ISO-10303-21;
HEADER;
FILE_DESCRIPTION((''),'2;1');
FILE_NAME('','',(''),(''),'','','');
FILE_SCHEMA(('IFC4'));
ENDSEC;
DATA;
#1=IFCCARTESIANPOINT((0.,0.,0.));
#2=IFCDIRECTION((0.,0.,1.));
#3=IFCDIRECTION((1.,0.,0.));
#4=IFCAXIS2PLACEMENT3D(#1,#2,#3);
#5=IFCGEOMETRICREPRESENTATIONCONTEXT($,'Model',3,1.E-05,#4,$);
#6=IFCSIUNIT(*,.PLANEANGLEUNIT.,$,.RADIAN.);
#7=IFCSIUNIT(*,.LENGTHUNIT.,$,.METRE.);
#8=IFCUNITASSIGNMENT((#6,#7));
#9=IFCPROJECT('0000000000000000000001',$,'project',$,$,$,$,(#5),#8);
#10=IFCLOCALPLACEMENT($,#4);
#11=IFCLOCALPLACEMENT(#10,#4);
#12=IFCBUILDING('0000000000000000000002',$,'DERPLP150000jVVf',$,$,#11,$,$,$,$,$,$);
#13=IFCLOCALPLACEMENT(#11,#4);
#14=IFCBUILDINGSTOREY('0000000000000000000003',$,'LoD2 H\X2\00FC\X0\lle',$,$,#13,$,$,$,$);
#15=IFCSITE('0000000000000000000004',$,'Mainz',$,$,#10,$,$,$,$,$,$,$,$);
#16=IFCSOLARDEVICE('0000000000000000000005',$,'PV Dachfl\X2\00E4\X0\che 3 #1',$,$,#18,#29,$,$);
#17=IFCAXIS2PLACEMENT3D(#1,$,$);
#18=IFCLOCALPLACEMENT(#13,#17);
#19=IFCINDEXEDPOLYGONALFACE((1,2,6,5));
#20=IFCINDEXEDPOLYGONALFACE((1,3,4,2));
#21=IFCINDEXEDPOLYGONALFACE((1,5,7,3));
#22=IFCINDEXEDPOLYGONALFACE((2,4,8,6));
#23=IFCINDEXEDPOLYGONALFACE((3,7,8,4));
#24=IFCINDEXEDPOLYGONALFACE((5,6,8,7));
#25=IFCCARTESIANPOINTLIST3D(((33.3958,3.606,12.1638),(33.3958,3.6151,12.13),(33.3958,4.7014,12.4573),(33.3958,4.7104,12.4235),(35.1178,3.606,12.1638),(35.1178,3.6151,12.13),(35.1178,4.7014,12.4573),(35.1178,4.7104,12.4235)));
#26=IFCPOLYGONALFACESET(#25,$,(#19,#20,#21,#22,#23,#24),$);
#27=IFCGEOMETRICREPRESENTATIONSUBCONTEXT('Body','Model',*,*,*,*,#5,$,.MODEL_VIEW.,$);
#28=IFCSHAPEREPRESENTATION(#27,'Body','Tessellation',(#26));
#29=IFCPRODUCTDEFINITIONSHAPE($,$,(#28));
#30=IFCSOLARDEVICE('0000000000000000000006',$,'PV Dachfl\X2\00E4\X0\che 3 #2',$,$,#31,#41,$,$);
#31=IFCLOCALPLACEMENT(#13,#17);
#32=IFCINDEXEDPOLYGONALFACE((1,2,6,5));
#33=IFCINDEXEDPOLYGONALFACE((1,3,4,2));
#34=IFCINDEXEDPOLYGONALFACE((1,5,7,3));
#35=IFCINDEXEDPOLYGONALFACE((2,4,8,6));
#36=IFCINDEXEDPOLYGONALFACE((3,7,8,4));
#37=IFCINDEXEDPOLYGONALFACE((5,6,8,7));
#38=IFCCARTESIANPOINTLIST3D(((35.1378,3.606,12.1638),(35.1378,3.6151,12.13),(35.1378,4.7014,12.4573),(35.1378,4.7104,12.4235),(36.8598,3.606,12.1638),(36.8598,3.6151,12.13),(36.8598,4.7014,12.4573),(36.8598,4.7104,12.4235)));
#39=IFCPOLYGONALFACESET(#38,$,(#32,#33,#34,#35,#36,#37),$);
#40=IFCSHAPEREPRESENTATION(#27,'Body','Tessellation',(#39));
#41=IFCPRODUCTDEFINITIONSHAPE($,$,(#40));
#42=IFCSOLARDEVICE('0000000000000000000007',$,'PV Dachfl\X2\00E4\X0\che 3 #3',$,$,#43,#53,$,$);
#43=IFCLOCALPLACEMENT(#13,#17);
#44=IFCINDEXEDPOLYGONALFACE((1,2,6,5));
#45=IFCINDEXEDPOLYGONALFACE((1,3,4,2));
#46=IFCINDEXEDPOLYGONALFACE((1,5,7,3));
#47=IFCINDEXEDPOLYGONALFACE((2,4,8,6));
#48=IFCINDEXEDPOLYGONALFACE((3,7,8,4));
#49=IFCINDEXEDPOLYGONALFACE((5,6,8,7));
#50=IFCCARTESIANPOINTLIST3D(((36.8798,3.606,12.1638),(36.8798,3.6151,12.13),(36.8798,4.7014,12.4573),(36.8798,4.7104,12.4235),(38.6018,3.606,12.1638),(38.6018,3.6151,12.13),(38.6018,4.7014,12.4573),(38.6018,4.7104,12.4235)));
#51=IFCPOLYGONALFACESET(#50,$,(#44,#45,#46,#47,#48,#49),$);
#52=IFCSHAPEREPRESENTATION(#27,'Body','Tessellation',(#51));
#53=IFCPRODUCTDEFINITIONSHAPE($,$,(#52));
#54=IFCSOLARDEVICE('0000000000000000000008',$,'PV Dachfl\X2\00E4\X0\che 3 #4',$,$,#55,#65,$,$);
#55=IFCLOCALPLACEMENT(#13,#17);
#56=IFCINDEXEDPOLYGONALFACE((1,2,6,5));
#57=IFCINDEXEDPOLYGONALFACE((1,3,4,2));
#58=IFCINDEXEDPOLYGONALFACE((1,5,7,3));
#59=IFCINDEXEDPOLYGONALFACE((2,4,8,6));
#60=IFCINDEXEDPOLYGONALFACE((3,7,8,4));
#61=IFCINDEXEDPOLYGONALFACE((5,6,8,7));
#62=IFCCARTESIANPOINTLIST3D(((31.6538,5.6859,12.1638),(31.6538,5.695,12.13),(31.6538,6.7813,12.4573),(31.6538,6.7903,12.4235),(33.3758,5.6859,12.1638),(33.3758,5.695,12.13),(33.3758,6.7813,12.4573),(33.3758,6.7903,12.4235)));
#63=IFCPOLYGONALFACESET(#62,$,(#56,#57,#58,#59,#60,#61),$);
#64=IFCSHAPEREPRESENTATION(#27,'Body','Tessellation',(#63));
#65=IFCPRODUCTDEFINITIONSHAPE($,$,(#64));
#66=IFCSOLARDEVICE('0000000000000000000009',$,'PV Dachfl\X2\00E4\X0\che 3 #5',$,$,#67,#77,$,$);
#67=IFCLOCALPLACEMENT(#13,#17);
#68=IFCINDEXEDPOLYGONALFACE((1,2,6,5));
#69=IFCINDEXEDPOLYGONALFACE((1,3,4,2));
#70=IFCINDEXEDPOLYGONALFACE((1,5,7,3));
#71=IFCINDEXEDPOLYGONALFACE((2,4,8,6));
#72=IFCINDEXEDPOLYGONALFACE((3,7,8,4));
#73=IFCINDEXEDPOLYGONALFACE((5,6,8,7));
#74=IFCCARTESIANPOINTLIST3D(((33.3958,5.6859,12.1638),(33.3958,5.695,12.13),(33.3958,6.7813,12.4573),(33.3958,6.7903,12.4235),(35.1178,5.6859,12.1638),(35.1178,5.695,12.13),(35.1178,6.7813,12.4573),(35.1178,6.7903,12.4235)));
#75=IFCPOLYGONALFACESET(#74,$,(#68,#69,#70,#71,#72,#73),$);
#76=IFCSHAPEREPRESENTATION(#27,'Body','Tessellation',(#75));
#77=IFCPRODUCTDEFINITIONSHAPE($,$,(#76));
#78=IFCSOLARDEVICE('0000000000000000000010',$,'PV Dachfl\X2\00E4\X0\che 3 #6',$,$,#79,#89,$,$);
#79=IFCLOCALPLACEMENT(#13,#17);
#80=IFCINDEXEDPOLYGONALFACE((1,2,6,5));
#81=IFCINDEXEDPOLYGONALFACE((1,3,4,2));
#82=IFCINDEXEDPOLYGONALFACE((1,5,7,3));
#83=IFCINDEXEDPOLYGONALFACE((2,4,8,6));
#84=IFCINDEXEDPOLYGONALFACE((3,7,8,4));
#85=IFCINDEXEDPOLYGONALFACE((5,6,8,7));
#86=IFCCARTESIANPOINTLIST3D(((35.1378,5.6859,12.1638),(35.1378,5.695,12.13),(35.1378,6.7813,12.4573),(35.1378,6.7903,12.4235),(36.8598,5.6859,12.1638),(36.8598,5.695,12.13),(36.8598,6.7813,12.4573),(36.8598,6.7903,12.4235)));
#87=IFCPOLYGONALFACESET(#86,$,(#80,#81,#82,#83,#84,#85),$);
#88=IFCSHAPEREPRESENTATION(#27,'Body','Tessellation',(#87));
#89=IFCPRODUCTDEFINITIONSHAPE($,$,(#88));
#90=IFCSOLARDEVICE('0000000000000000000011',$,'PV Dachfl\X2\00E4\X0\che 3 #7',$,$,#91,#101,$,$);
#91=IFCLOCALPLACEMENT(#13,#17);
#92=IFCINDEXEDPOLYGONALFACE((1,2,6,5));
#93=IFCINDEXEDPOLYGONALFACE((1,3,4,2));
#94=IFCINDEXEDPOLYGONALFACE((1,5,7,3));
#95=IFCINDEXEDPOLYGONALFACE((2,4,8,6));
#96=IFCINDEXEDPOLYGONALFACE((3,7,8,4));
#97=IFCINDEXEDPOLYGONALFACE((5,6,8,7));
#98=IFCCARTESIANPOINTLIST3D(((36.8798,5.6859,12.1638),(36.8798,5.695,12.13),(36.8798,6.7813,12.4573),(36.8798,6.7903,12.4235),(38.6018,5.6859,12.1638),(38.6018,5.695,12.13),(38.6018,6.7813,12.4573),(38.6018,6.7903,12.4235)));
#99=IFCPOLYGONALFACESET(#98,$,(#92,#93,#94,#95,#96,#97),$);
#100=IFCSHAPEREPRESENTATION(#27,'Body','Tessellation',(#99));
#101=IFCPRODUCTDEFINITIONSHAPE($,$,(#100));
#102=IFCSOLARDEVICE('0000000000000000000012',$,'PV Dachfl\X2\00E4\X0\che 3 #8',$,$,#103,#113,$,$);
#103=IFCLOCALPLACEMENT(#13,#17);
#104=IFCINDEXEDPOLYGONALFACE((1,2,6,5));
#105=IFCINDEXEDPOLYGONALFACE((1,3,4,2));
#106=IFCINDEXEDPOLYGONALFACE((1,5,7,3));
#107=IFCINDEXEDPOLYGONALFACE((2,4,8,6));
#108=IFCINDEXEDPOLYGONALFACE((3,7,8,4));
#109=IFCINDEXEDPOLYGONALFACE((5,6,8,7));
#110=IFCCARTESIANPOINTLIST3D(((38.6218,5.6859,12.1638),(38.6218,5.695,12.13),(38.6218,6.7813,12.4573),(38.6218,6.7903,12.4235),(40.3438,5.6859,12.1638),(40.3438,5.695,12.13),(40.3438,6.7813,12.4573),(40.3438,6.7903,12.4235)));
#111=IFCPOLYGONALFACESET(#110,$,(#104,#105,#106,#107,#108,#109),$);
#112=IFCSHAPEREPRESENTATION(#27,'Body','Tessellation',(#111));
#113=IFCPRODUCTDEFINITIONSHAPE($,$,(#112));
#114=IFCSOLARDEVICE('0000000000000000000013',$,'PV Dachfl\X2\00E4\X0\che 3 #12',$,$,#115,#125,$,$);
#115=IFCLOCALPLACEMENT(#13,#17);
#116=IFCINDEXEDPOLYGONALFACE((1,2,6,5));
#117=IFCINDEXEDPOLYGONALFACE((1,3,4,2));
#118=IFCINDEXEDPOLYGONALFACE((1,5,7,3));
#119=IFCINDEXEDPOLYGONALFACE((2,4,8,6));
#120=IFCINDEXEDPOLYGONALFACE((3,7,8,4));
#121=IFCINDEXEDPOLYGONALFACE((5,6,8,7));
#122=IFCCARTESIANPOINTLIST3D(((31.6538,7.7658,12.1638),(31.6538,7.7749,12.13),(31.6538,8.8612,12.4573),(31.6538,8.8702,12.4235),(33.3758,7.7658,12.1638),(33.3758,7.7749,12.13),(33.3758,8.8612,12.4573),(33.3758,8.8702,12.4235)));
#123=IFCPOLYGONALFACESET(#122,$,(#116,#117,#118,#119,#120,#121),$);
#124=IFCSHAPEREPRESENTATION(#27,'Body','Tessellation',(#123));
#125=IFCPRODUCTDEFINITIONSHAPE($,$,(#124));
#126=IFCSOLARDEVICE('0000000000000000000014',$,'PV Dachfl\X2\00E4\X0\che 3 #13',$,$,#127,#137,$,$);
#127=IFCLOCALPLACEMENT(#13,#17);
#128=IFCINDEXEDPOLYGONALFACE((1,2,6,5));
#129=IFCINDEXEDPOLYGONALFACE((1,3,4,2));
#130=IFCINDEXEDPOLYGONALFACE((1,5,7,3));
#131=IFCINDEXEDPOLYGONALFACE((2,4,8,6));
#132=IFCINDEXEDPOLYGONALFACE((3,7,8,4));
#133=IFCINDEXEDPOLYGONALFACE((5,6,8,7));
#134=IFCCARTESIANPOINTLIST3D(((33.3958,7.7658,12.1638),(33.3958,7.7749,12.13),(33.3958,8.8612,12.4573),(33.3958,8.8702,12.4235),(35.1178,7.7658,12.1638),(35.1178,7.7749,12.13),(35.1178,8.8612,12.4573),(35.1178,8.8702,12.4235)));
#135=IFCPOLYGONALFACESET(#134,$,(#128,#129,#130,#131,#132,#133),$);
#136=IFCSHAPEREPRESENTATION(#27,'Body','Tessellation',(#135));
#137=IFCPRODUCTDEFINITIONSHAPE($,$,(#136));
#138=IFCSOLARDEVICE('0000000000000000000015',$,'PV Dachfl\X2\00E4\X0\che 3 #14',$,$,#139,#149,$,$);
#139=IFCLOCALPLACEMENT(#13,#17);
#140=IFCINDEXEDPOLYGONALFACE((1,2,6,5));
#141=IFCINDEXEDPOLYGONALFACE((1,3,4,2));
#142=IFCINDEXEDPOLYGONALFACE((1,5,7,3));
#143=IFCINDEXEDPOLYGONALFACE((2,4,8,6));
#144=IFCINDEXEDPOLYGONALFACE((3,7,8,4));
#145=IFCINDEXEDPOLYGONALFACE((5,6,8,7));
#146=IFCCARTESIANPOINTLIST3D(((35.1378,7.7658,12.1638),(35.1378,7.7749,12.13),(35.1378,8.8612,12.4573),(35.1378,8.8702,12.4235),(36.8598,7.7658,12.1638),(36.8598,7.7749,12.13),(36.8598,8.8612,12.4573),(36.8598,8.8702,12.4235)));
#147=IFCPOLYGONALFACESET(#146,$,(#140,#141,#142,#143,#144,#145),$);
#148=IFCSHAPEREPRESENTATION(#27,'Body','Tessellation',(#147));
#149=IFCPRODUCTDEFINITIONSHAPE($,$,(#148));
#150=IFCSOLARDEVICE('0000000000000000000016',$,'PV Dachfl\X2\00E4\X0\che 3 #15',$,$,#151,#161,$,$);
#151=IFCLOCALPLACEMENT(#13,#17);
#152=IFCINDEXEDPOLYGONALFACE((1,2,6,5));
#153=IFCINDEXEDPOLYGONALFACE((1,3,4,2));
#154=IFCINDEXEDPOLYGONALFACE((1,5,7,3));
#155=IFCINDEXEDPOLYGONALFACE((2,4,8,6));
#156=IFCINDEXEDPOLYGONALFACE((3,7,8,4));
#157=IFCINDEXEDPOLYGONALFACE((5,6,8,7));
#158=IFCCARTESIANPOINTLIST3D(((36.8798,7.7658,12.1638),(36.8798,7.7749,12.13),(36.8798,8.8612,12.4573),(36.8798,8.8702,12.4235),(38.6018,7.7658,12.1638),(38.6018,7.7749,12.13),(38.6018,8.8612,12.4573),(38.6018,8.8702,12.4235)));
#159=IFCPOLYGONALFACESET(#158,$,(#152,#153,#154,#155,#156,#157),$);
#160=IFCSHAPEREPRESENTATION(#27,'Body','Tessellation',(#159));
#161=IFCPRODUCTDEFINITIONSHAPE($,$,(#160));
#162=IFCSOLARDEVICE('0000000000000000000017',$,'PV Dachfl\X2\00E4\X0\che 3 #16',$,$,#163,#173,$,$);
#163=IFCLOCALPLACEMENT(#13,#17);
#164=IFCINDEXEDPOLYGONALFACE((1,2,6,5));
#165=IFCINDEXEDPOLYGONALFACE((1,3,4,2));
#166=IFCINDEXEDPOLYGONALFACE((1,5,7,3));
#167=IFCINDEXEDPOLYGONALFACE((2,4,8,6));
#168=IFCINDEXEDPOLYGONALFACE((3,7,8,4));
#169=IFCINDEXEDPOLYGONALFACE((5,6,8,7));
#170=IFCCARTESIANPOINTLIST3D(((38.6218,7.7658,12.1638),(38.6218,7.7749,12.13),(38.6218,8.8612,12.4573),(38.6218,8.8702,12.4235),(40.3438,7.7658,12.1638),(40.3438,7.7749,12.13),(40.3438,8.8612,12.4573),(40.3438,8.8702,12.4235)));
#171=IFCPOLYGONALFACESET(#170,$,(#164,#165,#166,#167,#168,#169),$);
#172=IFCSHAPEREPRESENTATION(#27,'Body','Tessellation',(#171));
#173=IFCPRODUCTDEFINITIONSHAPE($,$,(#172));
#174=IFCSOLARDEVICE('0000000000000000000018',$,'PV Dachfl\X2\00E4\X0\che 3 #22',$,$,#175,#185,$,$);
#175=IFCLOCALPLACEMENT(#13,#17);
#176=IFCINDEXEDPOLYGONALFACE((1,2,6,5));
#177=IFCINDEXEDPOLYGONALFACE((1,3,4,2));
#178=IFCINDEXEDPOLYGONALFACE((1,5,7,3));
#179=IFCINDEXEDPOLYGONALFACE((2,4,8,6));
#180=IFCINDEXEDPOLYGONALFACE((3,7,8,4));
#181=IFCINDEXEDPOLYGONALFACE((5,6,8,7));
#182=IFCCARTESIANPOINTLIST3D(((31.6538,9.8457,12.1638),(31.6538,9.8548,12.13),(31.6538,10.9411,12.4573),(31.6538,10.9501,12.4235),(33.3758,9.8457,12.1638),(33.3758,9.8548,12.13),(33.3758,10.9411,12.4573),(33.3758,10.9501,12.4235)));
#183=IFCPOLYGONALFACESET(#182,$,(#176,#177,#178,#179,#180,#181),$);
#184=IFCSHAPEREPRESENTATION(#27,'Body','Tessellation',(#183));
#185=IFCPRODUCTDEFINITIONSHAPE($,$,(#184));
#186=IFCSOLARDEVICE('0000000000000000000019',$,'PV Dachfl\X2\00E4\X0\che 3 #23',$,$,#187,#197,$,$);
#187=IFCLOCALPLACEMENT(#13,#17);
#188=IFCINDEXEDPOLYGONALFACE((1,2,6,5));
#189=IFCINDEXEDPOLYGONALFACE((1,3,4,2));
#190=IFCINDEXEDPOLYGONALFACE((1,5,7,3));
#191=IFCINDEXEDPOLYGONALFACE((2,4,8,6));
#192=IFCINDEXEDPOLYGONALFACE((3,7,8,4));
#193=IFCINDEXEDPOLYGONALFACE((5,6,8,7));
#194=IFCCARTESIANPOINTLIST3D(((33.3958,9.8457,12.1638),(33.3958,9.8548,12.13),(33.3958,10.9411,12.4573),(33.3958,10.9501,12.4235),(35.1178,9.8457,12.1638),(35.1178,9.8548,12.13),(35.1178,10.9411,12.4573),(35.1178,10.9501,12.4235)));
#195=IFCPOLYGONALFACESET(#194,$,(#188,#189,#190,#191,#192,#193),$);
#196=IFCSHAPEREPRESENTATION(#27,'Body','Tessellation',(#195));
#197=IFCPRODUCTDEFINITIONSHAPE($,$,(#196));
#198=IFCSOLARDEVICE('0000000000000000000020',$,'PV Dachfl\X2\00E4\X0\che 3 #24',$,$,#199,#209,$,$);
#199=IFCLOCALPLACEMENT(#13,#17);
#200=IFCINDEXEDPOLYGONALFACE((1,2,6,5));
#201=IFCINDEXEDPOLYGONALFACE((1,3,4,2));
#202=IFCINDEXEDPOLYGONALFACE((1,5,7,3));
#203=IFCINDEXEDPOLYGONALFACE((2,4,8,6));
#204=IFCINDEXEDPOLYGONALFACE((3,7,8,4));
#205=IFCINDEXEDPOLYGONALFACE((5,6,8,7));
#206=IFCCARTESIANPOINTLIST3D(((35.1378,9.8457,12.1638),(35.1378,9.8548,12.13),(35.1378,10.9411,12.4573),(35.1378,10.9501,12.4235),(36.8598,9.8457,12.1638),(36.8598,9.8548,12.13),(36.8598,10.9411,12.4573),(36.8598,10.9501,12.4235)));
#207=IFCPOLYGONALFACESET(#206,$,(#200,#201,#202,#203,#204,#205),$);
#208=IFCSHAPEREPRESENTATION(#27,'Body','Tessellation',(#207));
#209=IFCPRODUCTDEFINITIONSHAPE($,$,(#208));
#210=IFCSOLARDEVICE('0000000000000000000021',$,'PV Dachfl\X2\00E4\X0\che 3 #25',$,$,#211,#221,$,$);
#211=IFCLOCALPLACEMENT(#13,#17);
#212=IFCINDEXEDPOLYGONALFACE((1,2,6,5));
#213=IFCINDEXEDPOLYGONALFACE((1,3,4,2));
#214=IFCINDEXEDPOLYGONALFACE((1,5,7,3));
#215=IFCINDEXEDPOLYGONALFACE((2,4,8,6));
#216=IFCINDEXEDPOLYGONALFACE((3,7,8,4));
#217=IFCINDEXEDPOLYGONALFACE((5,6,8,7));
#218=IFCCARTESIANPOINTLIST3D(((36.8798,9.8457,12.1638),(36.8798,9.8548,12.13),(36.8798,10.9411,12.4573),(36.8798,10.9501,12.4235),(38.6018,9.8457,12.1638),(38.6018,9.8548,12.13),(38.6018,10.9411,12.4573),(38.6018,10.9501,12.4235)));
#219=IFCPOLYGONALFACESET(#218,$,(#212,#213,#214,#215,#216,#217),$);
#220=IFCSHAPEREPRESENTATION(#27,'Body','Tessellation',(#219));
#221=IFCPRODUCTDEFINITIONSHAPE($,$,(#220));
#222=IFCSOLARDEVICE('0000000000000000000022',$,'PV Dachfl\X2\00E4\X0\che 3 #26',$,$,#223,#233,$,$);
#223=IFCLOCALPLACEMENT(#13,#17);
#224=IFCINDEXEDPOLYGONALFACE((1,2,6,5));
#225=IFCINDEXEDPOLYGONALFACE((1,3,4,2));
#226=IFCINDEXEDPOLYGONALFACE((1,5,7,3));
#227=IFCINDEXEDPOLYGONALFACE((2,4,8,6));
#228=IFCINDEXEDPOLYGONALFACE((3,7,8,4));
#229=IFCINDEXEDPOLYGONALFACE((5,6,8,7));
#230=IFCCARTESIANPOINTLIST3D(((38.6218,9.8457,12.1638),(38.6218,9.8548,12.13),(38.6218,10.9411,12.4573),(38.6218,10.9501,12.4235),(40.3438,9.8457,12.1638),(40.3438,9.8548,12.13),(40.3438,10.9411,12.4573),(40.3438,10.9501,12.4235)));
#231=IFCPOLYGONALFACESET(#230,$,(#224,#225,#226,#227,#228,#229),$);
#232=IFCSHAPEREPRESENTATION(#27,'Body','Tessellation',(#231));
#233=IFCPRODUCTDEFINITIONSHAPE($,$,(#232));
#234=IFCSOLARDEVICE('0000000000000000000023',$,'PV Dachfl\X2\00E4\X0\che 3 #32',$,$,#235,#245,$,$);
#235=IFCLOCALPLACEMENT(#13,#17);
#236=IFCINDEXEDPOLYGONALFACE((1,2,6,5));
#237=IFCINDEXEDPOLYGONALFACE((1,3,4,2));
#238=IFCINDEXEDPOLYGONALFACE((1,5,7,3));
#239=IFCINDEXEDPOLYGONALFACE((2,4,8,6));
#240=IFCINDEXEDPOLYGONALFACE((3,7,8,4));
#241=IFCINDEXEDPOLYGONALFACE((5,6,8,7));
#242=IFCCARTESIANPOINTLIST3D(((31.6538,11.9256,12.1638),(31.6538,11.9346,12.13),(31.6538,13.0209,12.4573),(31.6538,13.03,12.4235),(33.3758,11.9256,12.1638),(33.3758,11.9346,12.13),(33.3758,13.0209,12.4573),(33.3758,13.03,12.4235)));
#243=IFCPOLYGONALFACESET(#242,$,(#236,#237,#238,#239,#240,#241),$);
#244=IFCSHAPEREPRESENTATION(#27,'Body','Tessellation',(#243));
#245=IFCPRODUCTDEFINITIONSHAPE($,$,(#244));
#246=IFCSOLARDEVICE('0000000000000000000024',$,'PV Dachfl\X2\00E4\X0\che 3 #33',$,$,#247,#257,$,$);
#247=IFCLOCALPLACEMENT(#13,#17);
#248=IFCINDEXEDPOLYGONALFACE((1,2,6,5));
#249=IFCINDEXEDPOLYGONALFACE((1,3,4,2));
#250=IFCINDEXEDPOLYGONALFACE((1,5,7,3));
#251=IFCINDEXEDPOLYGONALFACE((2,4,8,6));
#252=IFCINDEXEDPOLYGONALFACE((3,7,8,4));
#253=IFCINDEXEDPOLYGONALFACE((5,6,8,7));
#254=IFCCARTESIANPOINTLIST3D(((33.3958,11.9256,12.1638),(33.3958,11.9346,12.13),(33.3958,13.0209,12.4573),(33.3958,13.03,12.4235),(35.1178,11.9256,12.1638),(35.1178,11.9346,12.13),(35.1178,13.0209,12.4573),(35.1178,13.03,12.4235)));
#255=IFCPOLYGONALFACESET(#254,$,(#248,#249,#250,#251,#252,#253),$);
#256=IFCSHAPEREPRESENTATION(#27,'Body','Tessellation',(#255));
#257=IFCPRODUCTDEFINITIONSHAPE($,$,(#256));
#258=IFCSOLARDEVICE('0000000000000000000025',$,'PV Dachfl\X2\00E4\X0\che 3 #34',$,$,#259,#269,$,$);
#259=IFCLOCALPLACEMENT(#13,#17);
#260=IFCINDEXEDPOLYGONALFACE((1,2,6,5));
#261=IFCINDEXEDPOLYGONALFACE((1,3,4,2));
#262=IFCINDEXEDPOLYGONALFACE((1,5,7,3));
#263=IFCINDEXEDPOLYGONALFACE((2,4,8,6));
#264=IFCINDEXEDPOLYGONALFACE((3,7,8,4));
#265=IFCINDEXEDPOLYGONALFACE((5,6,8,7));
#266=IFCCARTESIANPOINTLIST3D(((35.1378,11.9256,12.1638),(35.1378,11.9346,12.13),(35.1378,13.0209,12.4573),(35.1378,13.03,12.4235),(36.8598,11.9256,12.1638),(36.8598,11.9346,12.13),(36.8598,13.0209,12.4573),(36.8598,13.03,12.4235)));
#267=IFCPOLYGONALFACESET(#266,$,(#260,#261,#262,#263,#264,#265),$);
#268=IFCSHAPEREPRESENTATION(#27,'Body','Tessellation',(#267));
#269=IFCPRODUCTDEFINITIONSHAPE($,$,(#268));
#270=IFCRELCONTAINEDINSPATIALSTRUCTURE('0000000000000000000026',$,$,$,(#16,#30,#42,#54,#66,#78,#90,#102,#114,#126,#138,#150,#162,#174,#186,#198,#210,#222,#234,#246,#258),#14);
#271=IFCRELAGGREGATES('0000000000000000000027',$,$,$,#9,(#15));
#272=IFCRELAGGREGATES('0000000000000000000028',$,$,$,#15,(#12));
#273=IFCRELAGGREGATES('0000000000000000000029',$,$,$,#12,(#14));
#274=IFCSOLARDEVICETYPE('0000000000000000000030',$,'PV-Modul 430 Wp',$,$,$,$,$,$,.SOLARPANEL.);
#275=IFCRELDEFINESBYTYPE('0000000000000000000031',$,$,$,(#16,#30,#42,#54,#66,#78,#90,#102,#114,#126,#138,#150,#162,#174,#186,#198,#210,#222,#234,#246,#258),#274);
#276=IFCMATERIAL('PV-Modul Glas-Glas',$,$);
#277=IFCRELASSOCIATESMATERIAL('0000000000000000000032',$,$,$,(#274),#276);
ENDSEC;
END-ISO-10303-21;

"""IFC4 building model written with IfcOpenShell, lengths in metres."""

from ifc_helpers import new_model, si_unit, frame, frame_2d, origin, origin_with_axes, place, context, subcontext, project, spatial, rectangle, extrude, source, transform, mapped, material, type_object, type_shapes, element, save


model = new_model("IFC4")

# Units and contexts
model_context = context("Model", 3, precision=1e-05, world=origin_with_axes())
body_context = subcontext(model_context, "Body", "Model", "MODEL_VIEW")
ifc_project = project(units=[si_unit("PLANEANGLEUNIT", "RADIAN"), si_unit("LENGTHUNIT", "METRE")], contexts=[model_context])

# Site, building, storey
site_placement = place(None, origin_with_axes())
site = spatial("IfcSite", under=ifc_project, at=site_placement, Name="Mainz")
building_placement = place(site_placement, origin_with_axes())
building = spatial("IfcBuilding", under=site, at=building_placement, Name="DERPLP150000jVVf")
storey_placement = place(building_placement, origin_with_axes())
storey = spatial("IfcBuildingStorey", under=building, at=storey_placement, Name="LoD2 Hülle")

# Solar devices
ifc_material = material(Name="PV-Modul Glas-Glas")
solar_device_type = type_object("IfcSolarDeviceType", Name="PV-Modul 430 Wp", PredefinedType="SOLARPANEL", material=ifc_material)
shared_shape = source(origin_with_axes(), body_context, "Body", "SweptSolid", [
    extrude(rectangle(XDim=1.722, YDim=1.134, at=frame_2d((0.861, 0.567))), origin(), (0.0, 0.0, 1.0), 0.035),
])
type_shapes(solar_device_type, [shared_shape])
for number, where, z_axis, x_axis, name in (
    (1, (33.3958, 3.6151, 12.13), (0.0, -0.258819, 0.965926), (1.0, 0.0, 0.0), "PV Dachfläche 3 #1"),
    (2, (35.1378, 3.6151, 12.13), (0.0, -0.258819, 0.965926), (1.0, 0.0, 0.0), "PV Dachfläche 3 #2"),
    (3, (36.8798, 3.6151, 12.13), (0.0, -0.258819, 0.965926), (1.0, 0.0, 0.0), "PV Dachfläche 3 #3"),
    (4, (31.6538, 5.695, 12.13), (0.0, -0.258819, 0.965926), (1.0, 0.0, 0.0), "PV Dachfläche 3 #4"),
    (5, (33.3958, 5.695, 12.13), (0.0, -0.258819, 0.965926), (1.0, 0.0, 0.0), "PV Dachfläche 3 #5"),
    (6, (35.1378, 5.695, 12.13), (0.0, -0.258819, 0.965926), (1.0, 0.0, 0.0), "PV Dachfläche 3 #6"),
    (7, (36.8798, 5.695, 12.13), (0.0, -0.258819, 0.965926), (1.0, 0.0, 0.0), "PV Dachfläche 3 #7"),
    (8, (38.6218, 5.695, 12.13), (0.0, -0.258819, 0.965926), (1.0, 0.0, 0.0), "PV Dachfläche 3 #8"),
    (9, (31.6538, 7.7749, 12.13), (0.0, -0.258819, 0.965926), (1.0, 0.0, 0.0), "PV Dachfläche 3 #12"),
    (10, (33.3958, 7.7749, 12.13), (0.0, -0.258819, 0.965926), (1.0, 0.0, 0.0), "PV Dachfläche 3 #13"),
    (11, (35.1378, 7.7749, 12.13), (0.0, -0.258819, 0.965926), (1.0, 0.0, 0.0), "PV Dachfläche 3 #14"),
    (12, (36.8798, 7.7749, 12.13), (0.0, -0.258819, 0.965926), (1.0, 0.0, 0.0), "PV Dachfläche 3 #15"),
    (13, (38.6218, 7.7749, 12.13), (0.0, -0.258819, 0.965926), (1.0, 0.0, 0.0), "PV Dachfläche 3 #16"),
    (14, (31.6538, 9.8548, 12.13), (0.0, -0.258819, 0.965926), (1.0, 0.0, 0.0), "PV Dachfläche 3 #22"),
    (15, (33.3958, 9.8548, 12.13), (0.0, -0.258819, 0.965926), (1.0, 0.0, 0.0), "PV Dachfläche 3 #23"),
    (16, (35.1378, 9.8548, 12.13), (0.0, -0.258819, 0.965926), (1.0, 0.0, 0.0), "PV Dachfläche 3 #24"),
    (17, (36.8798, 9.8548, 12.13), (0.0, -0.258819, 0.965926), (1.0, 0.0, 0.0), "PV Dachfläche 3 #25"),
    (18, (38.6218, 9.8548, 12.13), (0.0, -0.258819, 0.965926), (1.0, 0.0, 0.0), "PV Dachfläche 3 #26"),
    (19, (31.6538, 11.9346, 12.13), (0.0, -0.258819, 0.965926), (1.0, 0.0, 0.0), "PV Dachfläche 3 #32"),
    (20, (33.3958, 11.9346, 12.13), (0.0, -0.258819, 0.965926), (1.0, 0.0, 0.0), "PV Dachfläche 3 #33"),
    (21, (35.1378, 11.9346, 12.13), (0.0, -0.258819, 0.965926), (1.0, 0.0, 0.0), "PV Dachfläche 3 #34"),
):
    element("IfcSolarDevice", number, at=place(storey_placement, frame(where, z_axis=z_axis, x_axis=x_axis)), inside=storey, type_object=solar_device_type, Name=name, context=body_context, shape_type="MappedRepresentation", body=[
        mapped(shared_shape, transform((0.0, 0.0, 0.0), x_axis=(1.0, 0.0, 0.0), y_axis=(0.0, 1.0, 0.0), z_axis=(0.0, 0.0, 1.0), scale=1.0)),
    ])

save(model, "model.ifc")
